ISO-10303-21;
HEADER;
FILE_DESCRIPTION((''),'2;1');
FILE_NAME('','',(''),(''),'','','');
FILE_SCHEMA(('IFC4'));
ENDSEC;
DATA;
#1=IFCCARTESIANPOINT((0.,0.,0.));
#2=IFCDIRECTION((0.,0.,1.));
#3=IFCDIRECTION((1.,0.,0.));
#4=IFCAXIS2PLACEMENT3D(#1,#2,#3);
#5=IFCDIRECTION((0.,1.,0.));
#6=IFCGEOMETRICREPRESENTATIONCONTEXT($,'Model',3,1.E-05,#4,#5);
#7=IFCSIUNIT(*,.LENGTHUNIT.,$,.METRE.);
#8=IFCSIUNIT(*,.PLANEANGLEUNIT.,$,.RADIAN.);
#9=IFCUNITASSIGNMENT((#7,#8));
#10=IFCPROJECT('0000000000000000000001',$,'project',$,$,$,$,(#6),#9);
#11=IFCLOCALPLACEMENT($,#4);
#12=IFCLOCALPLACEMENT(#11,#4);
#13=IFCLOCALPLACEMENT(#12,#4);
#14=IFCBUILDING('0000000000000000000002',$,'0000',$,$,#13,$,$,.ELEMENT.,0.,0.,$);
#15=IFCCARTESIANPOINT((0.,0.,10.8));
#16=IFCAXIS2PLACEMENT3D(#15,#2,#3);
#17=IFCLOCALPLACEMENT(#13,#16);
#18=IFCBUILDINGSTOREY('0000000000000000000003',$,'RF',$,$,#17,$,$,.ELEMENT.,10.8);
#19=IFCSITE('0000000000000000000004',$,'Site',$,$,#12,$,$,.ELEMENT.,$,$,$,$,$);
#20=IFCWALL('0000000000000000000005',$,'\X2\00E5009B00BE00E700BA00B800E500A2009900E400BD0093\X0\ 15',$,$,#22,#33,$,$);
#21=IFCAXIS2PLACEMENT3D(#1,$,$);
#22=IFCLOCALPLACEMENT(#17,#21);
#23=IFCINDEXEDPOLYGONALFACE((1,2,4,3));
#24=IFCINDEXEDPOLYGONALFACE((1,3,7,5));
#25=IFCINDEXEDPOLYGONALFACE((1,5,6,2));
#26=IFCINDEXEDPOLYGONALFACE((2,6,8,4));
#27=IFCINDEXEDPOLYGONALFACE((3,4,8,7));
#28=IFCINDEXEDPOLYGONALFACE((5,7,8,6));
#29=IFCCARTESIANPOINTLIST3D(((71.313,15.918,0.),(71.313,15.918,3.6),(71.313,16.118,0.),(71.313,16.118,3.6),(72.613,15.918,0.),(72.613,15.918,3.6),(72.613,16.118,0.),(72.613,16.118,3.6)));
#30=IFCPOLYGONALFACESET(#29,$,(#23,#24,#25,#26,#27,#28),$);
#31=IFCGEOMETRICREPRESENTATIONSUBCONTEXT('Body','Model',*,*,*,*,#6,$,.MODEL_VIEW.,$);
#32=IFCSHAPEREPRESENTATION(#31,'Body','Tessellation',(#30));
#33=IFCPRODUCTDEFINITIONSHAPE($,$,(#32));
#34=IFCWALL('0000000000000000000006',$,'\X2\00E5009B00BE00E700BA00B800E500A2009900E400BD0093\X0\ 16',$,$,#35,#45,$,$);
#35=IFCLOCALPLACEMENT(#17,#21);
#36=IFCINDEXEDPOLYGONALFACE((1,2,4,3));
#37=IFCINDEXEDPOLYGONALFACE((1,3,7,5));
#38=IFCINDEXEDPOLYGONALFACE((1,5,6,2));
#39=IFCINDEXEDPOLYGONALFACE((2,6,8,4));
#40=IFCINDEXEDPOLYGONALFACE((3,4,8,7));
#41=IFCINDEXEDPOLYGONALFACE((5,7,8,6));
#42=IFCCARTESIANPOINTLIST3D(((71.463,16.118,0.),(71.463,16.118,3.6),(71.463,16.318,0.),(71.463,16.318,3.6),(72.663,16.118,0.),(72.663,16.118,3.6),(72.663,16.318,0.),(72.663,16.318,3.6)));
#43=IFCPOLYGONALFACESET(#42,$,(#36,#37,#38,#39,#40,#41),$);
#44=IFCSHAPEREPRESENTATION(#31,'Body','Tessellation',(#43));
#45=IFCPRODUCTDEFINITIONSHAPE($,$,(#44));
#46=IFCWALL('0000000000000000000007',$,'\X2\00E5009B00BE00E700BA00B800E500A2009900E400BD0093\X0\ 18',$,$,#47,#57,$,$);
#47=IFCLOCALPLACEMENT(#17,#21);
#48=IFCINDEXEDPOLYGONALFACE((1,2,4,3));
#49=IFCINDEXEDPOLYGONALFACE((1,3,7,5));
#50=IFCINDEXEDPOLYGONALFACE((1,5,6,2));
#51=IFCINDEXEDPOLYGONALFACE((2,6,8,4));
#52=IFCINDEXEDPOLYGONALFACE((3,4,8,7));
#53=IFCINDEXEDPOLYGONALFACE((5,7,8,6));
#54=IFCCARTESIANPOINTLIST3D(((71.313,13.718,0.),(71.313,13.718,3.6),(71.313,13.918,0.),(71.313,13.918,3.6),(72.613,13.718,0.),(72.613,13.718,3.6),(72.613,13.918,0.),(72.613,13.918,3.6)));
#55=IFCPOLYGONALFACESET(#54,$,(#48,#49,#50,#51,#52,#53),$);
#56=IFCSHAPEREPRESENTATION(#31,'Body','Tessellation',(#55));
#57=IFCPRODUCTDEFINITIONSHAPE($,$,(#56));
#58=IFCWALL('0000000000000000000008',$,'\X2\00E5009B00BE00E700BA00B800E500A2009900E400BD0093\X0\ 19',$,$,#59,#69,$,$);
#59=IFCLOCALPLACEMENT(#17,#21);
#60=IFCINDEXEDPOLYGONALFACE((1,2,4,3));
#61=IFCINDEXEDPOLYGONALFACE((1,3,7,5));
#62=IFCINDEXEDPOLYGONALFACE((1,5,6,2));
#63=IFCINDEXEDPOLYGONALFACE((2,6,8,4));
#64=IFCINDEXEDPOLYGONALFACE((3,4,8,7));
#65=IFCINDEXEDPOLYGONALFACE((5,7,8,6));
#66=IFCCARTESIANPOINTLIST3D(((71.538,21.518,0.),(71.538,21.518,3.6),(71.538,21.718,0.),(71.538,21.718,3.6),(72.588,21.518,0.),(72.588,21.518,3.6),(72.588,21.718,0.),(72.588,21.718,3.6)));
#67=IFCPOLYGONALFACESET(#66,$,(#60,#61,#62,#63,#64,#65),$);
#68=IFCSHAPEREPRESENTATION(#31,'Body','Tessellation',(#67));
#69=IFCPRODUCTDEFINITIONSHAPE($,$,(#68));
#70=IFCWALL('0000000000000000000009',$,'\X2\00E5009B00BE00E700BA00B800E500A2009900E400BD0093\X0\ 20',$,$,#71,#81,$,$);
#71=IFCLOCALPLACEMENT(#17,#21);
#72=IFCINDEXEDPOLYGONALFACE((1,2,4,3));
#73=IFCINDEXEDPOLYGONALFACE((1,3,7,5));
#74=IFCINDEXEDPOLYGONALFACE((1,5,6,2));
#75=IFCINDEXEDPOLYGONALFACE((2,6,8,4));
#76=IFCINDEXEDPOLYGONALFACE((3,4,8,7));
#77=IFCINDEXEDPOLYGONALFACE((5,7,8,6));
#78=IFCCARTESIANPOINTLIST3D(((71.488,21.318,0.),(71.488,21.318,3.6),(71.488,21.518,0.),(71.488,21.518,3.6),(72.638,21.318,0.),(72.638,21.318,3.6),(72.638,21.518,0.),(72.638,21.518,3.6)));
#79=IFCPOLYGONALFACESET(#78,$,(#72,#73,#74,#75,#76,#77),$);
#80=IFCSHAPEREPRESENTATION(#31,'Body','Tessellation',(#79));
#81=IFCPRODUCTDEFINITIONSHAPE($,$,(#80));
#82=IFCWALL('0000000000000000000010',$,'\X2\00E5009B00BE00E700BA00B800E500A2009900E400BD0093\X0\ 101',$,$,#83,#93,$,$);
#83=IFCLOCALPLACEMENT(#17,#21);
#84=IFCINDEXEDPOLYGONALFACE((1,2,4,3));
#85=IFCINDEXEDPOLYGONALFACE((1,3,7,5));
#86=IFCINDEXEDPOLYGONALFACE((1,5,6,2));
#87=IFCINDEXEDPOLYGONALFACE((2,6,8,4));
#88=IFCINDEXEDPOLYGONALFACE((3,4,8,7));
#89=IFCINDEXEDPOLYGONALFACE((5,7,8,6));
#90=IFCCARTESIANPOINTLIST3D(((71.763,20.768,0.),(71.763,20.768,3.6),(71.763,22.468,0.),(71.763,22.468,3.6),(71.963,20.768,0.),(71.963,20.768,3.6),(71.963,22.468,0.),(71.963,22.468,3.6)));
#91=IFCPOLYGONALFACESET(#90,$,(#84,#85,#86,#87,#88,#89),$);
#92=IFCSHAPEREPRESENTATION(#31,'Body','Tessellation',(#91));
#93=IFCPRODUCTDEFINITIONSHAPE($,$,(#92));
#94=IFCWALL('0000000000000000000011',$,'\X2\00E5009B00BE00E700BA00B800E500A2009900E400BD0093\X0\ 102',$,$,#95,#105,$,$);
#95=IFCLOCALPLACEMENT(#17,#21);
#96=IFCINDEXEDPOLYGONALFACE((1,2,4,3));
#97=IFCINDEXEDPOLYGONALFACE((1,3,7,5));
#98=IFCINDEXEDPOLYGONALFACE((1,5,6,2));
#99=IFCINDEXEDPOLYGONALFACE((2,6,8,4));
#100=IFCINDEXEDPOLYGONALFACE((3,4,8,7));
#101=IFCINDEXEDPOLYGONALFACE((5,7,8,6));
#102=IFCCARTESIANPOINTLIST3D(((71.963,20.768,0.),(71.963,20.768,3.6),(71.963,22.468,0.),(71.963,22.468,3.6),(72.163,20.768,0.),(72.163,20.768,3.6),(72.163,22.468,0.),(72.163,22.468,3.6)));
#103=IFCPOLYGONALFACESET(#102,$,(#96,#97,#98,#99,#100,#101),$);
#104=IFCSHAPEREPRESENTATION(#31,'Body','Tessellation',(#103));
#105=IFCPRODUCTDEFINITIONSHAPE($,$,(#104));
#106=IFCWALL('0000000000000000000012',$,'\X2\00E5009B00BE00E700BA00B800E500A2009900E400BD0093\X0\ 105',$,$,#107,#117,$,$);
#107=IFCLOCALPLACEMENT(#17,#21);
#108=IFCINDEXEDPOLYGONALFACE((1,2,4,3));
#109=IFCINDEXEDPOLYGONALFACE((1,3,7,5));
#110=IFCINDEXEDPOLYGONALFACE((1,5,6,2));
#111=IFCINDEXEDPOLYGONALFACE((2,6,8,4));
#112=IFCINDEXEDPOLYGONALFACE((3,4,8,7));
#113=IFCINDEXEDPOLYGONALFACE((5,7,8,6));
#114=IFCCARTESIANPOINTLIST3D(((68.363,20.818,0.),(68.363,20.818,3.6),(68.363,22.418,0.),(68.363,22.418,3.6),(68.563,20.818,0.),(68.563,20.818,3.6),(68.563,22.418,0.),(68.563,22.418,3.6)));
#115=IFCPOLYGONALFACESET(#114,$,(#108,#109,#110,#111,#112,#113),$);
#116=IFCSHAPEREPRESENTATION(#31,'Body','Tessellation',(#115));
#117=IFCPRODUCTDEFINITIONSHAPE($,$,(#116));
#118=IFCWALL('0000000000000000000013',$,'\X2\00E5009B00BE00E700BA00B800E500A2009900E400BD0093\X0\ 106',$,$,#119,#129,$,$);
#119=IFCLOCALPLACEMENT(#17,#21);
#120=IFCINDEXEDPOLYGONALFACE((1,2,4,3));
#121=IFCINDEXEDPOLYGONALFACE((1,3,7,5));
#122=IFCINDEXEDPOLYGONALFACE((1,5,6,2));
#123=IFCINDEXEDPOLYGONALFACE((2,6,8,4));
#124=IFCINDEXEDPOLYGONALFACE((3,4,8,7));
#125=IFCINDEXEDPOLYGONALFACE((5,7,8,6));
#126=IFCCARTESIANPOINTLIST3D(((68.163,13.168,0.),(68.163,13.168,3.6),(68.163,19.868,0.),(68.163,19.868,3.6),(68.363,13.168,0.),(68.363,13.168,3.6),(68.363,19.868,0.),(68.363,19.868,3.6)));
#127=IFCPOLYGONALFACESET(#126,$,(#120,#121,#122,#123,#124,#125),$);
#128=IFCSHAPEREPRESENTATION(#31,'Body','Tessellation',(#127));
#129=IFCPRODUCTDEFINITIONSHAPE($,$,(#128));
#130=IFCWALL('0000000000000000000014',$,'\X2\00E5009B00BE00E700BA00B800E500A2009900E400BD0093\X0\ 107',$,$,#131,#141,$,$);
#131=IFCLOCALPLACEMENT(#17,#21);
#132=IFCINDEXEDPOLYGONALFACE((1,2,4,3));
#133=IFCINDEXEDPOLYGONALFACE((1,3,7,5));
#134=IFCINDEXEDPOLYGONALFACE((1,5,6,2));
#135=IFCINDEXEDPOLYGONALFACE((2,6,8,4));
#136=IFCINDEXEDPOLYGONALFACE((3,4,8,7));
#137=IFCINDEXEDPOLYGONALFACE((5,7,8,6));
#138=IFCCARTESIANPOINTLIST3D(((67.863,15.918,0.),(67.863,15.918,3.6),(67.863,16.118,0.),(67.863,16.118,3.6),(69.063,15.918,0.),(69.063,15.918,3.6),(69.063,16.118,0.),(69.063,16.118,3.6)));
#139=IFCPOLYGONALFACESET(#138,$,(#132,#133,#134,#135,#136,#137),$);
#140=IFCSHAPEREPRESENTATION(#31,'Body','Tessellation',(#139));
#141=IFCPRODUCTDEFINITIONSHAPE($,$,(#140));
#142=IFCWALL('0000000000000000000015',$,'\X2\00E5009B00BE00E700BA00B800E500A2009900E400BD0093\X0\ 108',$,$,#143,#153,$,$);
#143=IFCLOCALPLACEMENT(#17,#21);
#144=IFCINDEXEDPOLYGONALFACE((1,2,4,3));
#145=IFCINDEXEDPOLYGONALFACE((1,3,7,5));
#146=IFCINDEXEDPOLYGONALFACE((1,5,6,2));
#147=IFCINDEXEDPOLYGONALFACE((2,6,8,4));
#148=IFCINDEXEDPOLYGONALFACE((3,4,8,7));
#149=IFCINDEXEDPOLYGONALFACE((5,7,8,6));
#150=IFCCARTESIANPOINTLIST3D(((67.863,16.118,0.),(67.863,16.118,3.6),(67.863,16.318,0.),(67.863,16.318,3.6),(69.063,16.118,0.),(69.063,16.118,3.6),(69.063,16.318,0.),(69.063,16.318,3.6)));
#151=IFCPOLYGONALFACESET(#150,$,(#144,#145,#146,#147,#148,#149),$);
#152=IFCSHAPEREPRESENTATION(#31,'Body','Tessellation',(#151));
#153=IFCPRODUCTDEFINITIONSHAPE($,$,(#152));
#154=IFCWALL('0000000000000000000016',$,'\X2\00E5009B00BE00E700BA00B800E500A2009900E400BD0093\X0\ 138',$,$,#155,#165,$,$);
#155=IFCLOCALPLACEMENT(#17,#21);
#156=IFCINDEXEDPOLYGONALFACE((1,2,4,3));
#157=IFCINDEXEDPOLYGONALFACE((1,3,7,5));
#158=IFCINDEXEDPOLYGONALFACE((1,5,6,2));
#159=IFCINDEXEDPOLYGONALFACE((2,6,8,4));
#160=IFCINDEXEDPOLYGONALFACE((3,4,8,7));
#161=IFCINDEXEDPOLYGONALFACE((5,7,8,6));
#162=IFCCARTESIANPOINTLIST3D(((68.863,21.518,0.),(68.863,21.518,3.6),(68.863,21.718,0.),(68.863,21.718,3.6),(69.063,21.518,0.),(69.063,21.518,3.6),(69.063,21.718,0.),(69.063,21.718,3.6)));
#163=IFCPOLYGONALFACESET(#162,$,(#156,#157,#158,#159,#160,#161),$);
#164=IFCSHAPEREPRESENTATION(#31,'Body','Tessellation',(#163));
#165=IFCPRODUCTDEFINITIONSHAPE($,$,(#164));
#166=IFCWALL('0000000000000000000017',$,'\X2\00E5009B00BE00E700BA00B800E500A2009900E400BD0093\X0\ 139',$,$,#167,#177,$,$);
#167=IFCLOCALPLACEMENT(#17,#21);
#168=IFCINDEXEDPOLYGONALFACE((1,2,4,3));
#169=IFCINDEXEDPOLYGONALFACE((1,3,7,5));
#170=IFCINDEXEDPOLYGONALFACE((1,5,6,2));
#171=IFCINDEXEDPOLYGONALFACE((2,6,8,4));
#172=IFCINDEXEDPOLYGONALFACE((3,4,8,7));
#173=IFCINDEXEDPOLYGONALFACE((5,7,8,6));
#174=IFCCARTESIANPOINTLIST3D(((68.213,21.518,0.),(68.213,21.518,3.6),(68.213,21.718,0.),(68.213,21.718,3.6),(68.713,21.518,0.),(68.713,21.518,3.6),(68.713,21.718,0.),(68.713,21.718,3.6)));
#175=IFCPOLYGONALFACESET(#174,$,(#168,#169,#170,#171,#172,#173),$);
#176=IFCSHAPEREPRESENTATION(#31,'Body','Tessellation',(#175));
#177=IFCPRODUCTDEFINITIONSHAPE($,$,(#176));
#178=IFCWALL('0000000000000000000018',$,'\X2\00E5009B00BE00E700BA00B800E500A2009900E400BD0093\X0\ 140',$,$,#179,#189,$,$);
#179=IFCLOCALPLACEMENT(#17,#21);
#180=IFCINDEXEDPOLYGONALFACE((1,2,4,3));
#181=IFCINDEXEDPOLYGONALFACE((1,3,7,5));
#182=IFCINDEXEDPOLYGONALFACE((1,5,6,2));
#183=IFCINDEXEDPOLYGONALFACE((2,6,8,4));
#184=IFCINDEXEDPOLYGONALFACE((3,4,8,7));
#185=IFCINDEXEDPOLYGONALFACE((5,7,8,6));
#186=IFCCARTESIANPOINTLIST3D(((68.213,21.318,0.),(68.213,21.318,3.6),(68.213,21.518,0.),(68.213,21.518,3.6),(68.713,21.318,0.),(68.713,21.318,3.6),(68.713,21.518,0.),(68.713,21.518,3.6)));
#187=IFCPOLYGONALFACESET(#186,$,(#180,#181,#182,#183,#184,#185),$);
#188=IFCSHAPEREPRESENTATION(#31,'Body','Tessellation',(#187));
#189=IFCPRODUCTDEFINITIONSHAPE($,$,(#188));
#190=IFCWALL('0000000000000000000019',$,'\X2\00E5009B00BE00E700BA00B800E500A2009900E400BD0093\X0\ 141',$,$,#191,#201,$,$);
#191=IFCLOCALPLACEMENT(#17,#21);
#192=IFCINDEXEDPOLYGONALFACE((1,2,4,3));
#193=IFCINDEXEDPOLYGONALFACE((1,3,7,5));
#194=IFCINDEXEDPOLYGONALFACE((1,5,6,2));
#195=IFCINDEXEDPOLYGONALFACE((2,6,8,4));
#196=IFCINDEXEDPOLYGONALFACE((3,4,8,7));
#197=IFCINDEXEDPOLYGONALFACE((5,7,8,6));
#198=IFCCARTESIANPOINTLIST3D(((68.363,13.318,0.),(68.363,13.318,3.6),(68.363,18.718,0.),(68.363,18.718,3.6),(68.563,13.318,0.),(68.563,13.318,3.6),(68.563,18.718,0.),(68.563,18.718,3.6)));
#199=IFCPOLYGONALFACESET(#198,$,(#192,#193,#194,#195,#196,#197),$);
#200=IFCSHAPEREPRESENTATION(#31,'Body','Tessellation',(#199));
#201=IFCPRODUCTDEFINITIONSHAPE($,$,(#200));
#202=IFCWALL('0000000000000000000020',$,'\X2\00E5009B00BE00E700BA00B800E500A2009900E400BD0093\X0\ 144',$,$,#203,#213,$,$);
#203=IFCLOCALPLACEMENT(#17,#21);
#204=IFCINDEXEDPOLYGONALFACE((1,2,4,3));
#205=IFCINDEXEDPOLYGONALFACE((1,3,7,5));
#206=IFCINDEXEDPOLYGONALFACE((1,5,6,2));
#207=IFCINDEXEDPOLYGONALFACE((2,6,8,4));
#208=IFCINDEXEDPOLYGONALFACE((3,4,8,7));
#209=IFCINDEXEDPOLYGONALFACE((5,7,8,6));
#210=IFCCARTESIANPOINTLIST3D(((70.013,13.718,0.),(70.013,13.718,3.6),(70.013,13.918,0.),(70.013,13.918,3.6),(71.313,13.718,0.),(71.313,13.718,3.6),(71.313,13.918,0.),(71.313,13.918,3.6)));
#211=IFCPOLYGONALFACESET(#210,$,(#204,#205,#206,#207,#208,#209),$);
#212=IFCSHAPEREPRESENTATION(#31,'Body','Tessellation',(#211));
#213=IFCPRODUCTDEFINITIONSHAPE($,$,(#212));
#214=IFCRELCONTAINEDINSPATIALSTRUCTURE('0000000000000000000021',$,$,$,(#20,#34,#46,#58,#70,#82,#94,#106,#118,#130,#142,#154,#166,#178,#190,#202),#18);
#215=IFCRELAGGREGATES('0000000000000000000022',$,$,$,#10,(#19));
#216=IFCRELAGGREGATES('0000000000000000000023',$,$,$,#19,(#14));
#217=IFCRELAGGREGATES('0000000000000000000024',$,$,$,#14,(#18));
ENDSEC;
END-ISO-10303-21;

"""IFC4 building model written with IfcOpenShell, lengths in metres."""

from ifc_helpers import new_model, si_unit, direction, frame, frame_2d, origin_with_axes, place, context, subcontext, project, spatial, rectangle, extrude, element, save


model = new_model("IFC4")

# Units and contexts
model_context = context("Model", 3, precision=1e-05, world=origin_with_axes(), true_north=direction((0.0, 1.0, 0.0)))
body_context = subcontext(model_context, "Body", "Model", "MODEL_VIEW")
ifc_project = project(units=[si_unit("LENGTHUNIT", "METRE"), si_unit("PLANEANGLEUNIT", "RADIAN")], contexts=[model_context])

# Site, building, storey
placement = place(None, origin_with_axes())
site_placement = place(placement, origin_with_axes())
site = spatial("IfcSite", under=ifc_project, at=site_placement, Name="Site", CompositionType="ELEMENT")
building_placement = place(site_placement, origin_with_axes())
building = spatial("IfcBuilding", under=site, at=building_placement, Name="0000", CompositionType="ELEMENT", ElevationOfRefHeight=0.0, ElevationOfTerrain=0.0)
storey_placement = place(building_placement, frame((0.0, 0.0, 10.8), z_axis=(0.0, 0.0, 1.0), x_axis=(1.0, 0.0, 0.0)))
storey = spatial("IfcBuildingStorey", under=building, at=storey_placement, Name="RF", CompositionType="ELEMENT", Elevation=10.8)

# Walls
wall_1_placement = place(storey_placement, frame((71.963, 16.018, 0.0), z_axis=(0.0, 0.0, 1.0), x_axis=(1.0, 0.0, 0.0)))
element("IfcWall", 1, at=wall_1_placement, inside=storey, Name="å\u009b¾çº¸å¢\u0099ä½\u0093 15", context=body_context, shape_type="SweptSolid", body=[
    extrude(rectangle(XDim=1.3, YDim=0.2, at=frame_2d((0.0, 0.0), x_axis=(1.0, 0.0, 0.0))), frame((0.0, 0.0, 0.0), z_axis=(0.0, 0.0, 1.0)), (0.0, 0.0, 1.0), 3.6),
])
wall_2_placement = place(storey_placement, frame((72.063, 16.218, 0.0), z_axis=(0.0, 0.0, 1.0), x_axis=(1.0, 0.0, 0.0)))
element("IfcWall", 2, at=wall_2_placement, inside=storey, Name="å\u009b¾çº¸å¢\u0099ä½\u0093 16", context=body_context, shape_type="SweptSolid", body=[
    extrude(rectangle(XDim=1.2, YDim=0.2, at=frame_2d((0.0, 0.0), x_axis=(1.0, 0.0, 0.0))), frame((0.0, 0.0, 0.0), z_axis=(0.0, 0.0, 1.0)), (0.0, 0.0, 1.0), 3.6),
])
wall_3_placement = place(storey_placement, frame((71.963, 13.818, 0.0), z_axis=(0.0, 0.0, 1.0), x_axis=(1.0, 0.0, 0.0)))
element("IfcWall", 3, at=wall_3_placement, inside=storey, Name="å\u009b¾çº¸å¢\u0099ä½\u0093 18", context=body_context, shape_type="SweptSolid", body=[
    extrude(rectangle(XDim=1.3, YDim=0.2, at=frame_2d((0.0, 0.0), x_axis=(1.0, 0.0, 0.0))), frame((0.0, 0.0, 0.0), z_axis=(0.0, 0.0, 1.0)), (0.0, 0.0, 1.0), 3.6),
])
wall_4_placement = place(storey_placement, frame((72.063, 21.618, 0.0), z_axis=(0.0, 0.0, 1.0), x_axis=(1.0, 0.0, 0.0)))
element("IfcWall", 4, at=wall_4_placement, inside=storey, Name="å\u009b¾çº¸å¢\u0099ä½\u0093 19", context=body_context, shape_type="SweptSolid", body=[
    extrude(rectangle(XDim=1.05, YDim=0.2, at=frame_2d((0.0, 0.0), x_axis=(1.0, 0.0, 0.0))), frame((0.0, 0.0, 0.0), z_axis=(0.0, 0.0, 1.0)), (0.0, 0.0, 1.0), 3.6),
])
wall_5_placement = place(storey_placement, frame((72.063, 21.418, 0.0), z_axis=(0.0, 0.0, 1.0), x_axis=(1.0, 0.0, 0.0)))
element("IfcWall", 5, at=wall_5_placement, inside=storey, Name="å\u009b¾çº¸å¢\u0099ä½\u0093 20", context=body_context, shape_type="SweptSolid", body=[
    extrude(rectangle(XDim=1.15, YDim=0.2, at=frame_2d((0.0, 0.0), x_axis=(1.0, 0.0, 0.0))), frame((0.0, 0.0, 0.0), z_axis=(0.0, 0.0, 1.0)), (0.0, 0.0, 1.0), 3.6),
])
for number, where, z_axis, x_axis, name in (
    (6, (71.863, 21.618, 0.0), (0.0, 0.0, 1.0), (0.0, 1.0, 0.0), "å\u009b¾çº¸å¢\u0099ä½\u0093 101"),
    (7, (72.063, 21.618, 0.0), (0.0, 0.0, 1.0), (0.0, 1.0, 0.0), "å\u009b¾çº¸å¢\u0099ä½\u0093 102"),
):
    element("IfcWall", number, at=place(storey_placement, frame(where, z_axis=z_axis, x_axis=x_axis)), inside=storey, Name=name, context=body_context, shape_type="SweptSolid", body=[
        extrude(rectangle(XDim=1.7, YDim=0.2, at=frame_2d((0.0, 0.0), x_axis=(1.0, 0.0, 0.0))), frame((0.0, 0.0, 0.0), z_axis=(0.0, 0.0, 1.0)), (0.0, 0.0, 1.0), 3.6),
    ])
wall_6_placement = place(storey_placement, frame((68.463, 21.618, 0.0), z_axis=(0.0, 0.0, 1.0), x_axis=(0.0, 1.0, 0.0)))
element("IfcWall", 8, at=wall_6_placement, inside=storey, Name="å\u009b¾çº¸å¢\u0099ä½\u0093 105", context=body_context, shape_type="SweptSolid", body=[
    extrude(rectangle(XDim=1.6, YDim=0.2, at=frame_2d((0.0, 0.0), x_axis=(1.0, 0.0, 0.0))), frame((0.0, 0.0, 0.0), z_axis=(0.0, 0.0, 1.0)), (0.0, 0.0, 1.0), 3.6),
])
wall_7_placement = place(storey_placement, frame((68.263, 16.518, 0.0), z_axis=(0.0, 0.0, 1.0), x_axis=(0.0, 1.0, 0.0)))
element("IfcWall", 9, at=wall_7_placement, inside=storey, Name="å\u009b¾çº¸å¢\u0099ä½\u0093 106", context=body_context, shape_type="SweptSolid", body=[
    extrude(rectangle(XDim=6.7, YDim=0.2, at=frame_2d((0.0, 0.0), x_axis=(1.0, 0.0, 0.0))), frame((0.0, 0.0, 0.0), z_axis=(0.0, 0.0, 1.0)), (0.0, 0.0, 1.0), 3.6),
])
for number, where, z_axis, x_axis, name in (
    (10, (68.463, 16.018, 0.0), (0.0, 0.0, 1.0), (1.0, 0.0, 0.0), "å\u009b¾çº¸å¢\u0099ä½\u0093 107"),
    (11, (68.463, 16.218, 0.0), (0.0, 0.0, 1.0), (1.0, 0.0, 0.0), "å\u009b¾çº¸å¢\u0099ä½\u0093 108"),
):
    element("IfcWall", number, at=place(storey_placement, frame(where, z_axis=z_axis, x_axis=x_axis)), inside=storey, Name=name, context=body_context, shape_type="SweptSolid", body=[
        extrude(rectangle(XDim=1.2, YDim=0.2, at=frame_2d((0.0, 0.0), x_axis=(1.0, 0.0, 0.0))), frame((0.0, 0.0, 0.0), z_axis=(0.0, 0.0, 1.0)), (0.0, 0.0, 1.0), 3.6),
    ])
wall_8_placement = place(storey_placement, frame((68.963, 21.618, 0.0), z_axis=(0.0, 0.0, 1.0), x_axis=(0.0, -1.0, 0.0)))
element("IfcWall", 12, at=wall_8_placement, inside=storey, Name="å\u009b¾çº¸å¢\u0099ä½\u0093 138", context=body_context, shape_type="SweptSolid", body=[
    extrude(rectangle(XDim=0.2, YDim=0.2, at=frame_2d((0.0, 0.0), x_axis=(1.0, 0.0, 0.0))), frame((0.0, 0.0, 0.0), z_axis=(0.0, 0.0, 1.0)), (0.0, 0.0, 1.0), 3.6),
])
for number, where, z_axis, x_axis, name in (
    (13, (68.463, 21.618, 0.0), (0.0, 0.0, 1.0), (1.0, 0.0, 0.0), "å\u009b¾çº¸å¢\u0099ä½\u0093 139"),
    (14, (68.463, 21.418, 0.0), (0.0, 0.0, 1.0), (1.0, 0.0, 0.0), "å\u009b¾çº¸å¢\u0099ä½\u0093 140"),
):
    element("IfcWall", number, at=place(storey_placement, frame(where, z_axis=z_axis, x_axis=x_axis)), inside=storey, Name=name, context=body_context, shape_type="SweptSolid", body=[
        extrude(rectangle(XDim=0.5, YDim=0.2, at=frame_2d((0.0, 0.0), x_axis=(1.0, 0.0, 0.0))), frame((0.0, 0.0, 0.0), z_axis=(0.0, 0.0, 1.0)), (0.0, 0.0, 1.0), 3.6),
    ])
wall_9_placement = place(storey_placement, frame((68.463, 16.018, 0.0), z_axis=(0.0, 0.0, 1.0), x_axis=(0.0, 1.0, 0.0)))
element("IfcWall", 15, at=wall_9_placement, inside=storey, Name="å\u009b¾çº¸å¢\u0099ä½\u0093 141", context=body_context, shape_type="SweptSolid", body=[
    extrude(rectangle(XDim=5.4, YDim=0.2, at=frame_2d((0.0, 0.0), x_axis=(1.0, 0.0, 0.0))), frame((0.0, 0.0, 0.0), z_axis=(0.0, 0.0, 1.0)), (0.0, 0.0, 1.0), 3.6),
])
wall_10_placement = place(storey_placement, frame((70.663, 13.818, 0.0), z_axis=(0.0, 0.0, 1.0), x_axis=(1.0, 0.0, 0.0)))
element("IfcWall", 16, at=wall_10_placement, inside=storey, Name="å\u009b¾çº¸å¢\u0099ä½\u0093 144", context=body_context, shape_type="SweptSolid", body=[
    extrude(rectangle(XDim=1.3, YDim=0.2, at=frame_2d((0.0, 0.0), x_axis=(1.0, 0.0, 0.0))), frame((0.0, 0.0, 0.0), z_axis=(0.0, 0.0, 1.0)), (0.0, 0.0, 1.0), 3.6),
])

save(model, "model.ifc")
